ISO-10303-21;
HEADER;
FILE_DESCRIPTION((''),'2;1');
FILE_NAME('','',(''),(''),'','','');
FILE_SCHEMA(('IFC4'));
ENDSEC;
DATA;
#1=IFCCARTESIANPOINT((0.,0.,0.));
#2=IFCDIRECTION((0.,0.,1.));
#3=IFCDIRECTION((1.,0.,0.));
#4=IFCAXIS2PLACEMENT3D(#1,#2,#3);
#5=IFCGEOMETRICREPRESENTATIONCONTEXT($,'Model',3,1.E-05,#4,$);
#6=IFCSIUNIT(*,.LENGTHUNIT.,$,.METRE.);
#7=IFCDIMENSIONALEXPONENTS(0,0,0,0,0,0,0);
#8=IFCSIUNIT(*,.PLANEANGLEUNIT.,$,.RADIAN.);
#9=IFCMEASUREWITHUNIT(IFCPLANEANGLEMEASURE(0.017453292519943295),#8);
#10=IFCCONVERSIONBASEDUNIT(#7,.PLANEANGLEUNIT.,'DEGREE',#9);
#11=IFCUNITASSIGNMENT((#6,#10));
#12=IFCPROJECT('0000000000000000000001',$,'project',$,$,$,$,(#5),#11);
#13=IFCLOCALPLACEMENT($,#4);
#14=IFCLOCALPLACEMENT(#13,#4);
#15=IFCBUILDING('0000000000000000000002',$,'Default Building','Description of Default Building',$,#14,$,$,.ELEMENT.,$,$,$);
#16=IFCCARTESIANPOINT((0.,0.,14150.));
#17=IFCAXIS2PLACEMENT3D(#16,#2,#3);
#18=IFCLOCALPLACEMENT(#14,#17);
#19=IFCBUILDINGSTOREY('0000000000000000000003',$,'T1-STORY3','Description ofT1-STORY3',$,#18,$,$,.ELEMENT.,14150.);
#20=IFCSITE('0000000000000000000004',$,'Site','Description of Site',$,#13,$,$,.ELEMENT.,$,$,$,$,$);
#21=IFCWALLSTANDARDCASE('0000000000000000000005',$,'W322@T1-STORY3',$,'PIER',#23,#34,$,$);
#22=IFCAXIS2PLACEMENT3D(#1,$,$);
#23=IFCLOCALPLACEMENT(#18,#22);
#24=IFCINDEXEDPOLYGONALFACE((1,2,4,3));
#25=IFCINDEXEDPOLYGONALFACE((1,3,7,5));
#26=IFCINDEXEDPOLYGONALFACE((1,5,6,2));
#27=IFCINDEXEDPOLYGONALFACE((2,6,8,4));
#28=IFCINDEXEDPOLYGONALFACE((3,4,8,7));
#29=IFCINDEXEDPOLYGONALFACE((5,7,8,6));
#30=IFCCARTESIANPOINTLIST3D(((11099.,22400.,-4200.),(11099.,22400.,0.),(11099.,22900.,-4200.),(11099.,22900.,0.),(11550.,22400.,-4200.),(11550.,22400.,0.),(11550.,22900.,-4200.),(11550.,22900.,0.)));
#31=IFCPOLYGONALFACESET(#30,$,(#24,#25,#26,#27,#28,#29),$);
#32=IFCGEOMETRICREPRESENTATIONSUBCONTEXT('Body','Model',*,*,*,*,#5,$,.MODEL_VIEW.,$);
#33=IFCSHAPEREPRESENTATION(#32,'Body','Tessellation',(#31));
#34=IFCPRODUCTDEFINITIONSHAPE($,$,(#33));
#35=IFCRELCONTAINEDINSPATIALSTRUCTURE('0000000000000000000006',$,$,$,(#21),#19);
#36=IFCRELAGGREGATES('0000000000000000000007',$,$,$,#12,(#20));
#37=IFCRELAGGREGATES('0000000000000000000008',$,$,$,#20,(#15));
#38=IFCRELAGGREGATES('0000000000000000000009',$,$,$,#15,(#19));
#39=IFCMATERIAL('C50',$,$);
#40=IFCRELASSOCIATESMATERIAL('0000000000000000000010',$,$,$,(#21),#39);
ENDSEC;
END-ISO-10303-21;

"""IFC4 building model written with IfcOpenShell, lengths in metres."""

from ifc_helpers import new_model, entity, si_unit, converted_unit, frame, origin_with_axes, place, context, subcontext, project, spatial, indexed_curve, outline, extrude, material, element, save


model = new_model("IFC4")

# Units and contexts
model_context = context("Model", 3, precision=1e-05, world=origin_with_axes())
body_context = subcontext(model_context, "Body", "Model", "MODEL_VIEW")
ifc_project = project(units=[si_unit("LENGTHUNIT", "METRE"), converted_unit("PLANEANGLEUNIT", "DEGREE", entity("IfcPlaneAngleMeasure", 0.017453292519943295), si_unit("PLANEANGLEUNIT", "RADIAN"), dimensions=[0, 0, 0, 0, 0, 0, 0])], contexts=[model_context])

# Site, building, storey
site_placement = place(None, origin_with_axes())
site = spatial("IfcSite", under=ifc_project, at=site_placement, Name="Site", Description="Description of Site", CompositionType="ELEMENT")
building_placement = place(site_placement, origin_with_axes())
building = spatial("IfcBuilding", under=site, at=building_placement, Name="Default Building", Description="Description of Default Building", CompositionType="ELEMENT")
storey_placement = place(building_placement, frame((0.0, 0.0, 14150.0), z_axis=(0.0, 0.0, 1.0), x_axis=(1.0, 0.0, 0.0)))
storey = spatial("IfcBuildingStorey", under=building, at=storey_placement, Name="T1-STORY3", Description="Description ofT1-STORY3", CompositionType="ELEMENT", Elevation=14150.0)

# Shared definitions
ifc_material_1 = material(Name="C50")

# Wall
wall_1_placement = place(storey_placement, frame((11099.0, 22650.0, -4200.0), z_axis=(0.0, 0.0, 1.0), x_axis=(1.0, 0.0, 0.0)))
element("IfcWallStandardCase", 1, at=wall_1_placement, inside=storey, material=ifc_material_1, Name="W322@T1-STORY3", ObjectType="PIER", context=body_context, shape_type="SweptSolid", body=[
    extrude(outline(indexed_curve([(0.0, -250.0), (0.0, 250.0), (451.0, 250.0), (451.0, -250.0), (0.0, -250.0)], self_intersect=False)), origin_with_axes(), (0.0, 0.0, 1.0), 4200.0),
])

save(model, "model.ifc")
